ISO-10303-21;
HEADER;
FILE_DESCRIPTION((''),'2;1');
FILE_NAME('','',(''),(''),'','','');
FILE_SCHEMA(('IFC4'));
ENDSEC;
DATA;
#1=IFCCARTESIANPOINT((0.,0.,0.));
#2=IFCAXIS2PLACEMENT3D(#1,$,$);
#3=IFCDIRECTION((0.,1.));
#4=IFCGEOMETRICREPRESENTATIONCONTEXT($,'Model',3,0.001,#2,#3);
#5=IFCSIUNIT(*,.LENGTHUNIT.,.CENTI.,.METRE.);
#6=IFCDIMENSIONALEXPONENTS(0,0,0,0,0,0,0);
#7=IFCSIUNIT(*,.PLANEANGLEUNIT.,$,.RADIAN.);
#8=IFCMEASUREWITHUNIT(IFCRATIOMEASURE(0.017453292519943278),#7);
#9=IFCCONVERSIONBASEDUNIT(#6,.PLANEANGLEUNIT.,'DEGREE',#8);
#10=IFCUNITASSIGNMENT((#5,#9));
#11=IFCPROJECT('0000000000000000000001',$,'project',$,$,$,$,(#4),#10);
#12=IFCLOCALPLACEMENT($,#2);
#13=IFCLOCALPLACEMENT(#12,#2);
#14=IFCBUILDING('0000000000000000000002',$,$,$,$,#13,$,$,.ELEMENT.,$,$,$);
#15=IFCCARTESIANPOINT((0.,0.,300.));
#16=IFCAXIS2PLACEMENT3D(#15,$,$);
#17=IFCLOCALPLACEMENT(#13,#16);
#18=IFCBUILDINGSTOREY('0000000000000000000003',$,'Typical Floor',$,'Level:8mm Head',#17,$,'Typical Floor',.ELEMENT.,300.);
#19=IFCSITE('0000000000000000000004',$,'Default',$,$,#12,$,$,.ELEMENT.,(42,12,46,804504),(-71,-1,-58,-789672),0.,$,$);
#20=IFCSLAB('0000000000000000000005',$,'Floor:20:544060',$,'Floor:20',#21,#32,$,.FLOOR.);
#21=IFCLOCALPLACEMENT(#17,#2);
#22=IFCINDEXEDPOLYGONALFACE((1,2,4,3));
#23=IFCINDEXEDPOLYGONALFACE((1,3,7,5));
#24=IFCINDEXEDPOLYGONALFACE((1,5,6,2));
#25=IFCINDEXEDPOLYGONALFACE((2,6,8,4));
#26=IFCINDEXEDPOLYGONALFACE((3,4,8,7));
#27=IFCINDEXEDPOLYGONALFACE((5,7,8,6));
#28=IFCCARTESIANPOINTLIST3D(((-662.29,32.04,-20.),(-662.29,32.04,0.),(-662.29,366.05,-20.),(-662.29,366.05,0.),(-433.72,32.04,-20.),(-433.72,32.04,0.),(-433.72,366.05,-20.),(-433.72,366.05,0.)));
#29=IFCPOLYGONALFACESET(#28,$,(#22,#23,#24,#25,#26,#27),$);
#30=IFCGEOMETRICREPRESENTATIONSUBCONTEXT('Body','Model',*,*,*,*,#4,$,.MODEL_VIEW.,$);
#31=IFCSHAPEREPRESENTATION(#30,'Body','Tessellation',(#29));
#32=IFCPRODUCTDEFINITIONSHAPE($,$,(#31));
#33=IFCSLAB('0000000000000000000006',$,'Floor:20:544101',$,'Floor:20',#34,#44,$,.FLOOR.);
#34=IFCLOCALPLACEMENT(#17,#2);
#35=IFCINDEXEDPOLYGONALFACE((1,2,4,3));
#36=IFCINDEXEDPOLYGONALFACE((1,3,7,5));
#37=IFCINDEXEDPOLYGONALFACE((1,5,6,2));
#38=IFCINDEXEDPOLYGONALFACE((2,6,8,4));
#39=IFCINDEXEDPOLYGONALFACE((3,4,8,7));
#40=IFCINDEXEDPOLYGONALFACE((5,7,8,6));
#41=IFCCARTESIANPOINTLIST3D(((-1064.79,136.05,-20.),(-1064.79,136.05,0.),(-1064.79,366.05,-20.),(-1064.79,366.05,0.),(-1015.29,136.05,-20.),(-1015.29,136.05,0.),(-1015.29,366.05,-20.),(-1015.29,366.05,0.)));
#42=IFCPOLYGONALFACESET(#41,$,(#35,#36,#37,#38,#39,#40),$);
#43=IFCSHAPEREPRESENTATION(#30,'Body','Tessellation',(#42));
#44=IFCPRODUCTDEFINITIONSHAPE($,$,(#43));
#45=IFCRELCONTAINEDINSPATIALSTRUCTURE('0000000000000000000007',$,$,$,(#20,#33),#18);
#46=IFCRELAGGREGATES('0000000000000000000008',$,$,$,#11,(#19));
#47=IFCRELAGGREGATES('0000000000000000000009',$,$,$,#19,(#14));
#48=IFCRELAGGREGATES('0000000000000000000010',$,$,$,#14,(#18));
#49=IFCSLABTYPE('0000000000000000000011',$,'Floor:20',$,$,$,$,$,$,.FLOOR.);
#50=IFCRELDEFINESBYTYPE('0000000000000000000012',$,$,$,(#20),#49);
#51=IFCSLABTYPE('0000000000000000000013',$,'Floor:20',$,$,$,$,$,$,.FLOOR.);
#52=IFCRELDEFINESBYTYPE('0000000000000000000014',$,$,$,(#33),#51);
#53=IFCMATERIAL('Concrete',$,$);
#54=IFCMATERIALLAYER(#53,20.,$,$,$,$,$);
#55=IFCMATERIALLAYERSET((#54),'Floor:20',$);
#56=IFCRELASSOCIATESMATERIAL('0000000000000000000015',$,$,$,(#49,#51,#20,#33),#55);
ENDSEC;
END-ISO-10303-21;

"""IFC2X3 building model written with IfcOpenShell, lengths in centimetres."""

from ifc_helpers import new_model, entity, si_unit, converted_unit, direction, frame, frame_2d, origin, origin_2d_with_axis, place, context, subcontext, project, spatial, rectangle, extrude, material, layer, layer_set, layer_usage, type_object, element, save


model = new_model("IFC2X3")

# Units and contexts
model_context = context("Model", 3, precision=0.001, world=origin(), true_north=direction((0.0, 1.0)))
body_context = subcontext(model_context, "Body", "Model", "MODEL_VIEW")
ifc_project = project(units=[si_unit("LENGTHUNIT", "METRE", prefix="CENTI"), converted_unit("PLANEANGLEUNIT", "DEGREE", entity("IfcRatioMeasure", 0.017453292519943278), si_unit("PLANEANGLEUNIT", "RADIAN"), dimensions=[0, 0, 0, 0, 0, 0, 0])], contexts=[model_context])

# Site, building, storey
site_placement = place(None, origin())
site = spatial("IfcSite", under=ifc_project, at=site_placement, Name="Default", CompositionType="ELEMENT", RefLatitude=(42, 12, 46, 804504), RefLongitude=(-71, -1, -58, -789672), RefElevation=0.0)
building_placement = place(site_placement, origin())
building = spatial("IfcBuilding", under=site, at=building_placement, CompositionType="ELEMENT")
storey_placement = place(building_placement, frame((0.0, 0.0, 300.0)))
storey = spatial("IfcBuildingStorey", under=building, at=storey_placement, Name="Typical Floor", ObjectType="Level:8mm Head", LongName="Typical Floor", CompositionType="ELEMENT", Elevation=300.0)

# Shared definitions
ifc_material = material(Name="Concrete")

# Slabs
ifc_layer = layer(ifc_material, 20.0)
ifc_layer_set = layer_set([ifc_layer], Name="Floor:20")
ifc_layer_usage_1 = layer_usage(ifc_layer_set, "AXIS3", "POSITIVE", 0.0)
slab_type_1 = type_object("IfcSlabType", Name="Floor:20", PredefinedType="FLOOR", material=ifc_layer_set)
slab_1_placement = place(storey_placement, origin())
element("IfcSlab", 1, at=slab_1_placement, inside=storey, type_object=slab_type_1, material=ifc_layer_usage_1, Name="Floor:20:544060", ObjectType="Floor:20", PredefinedType="FLOOR", context=body_context, shape_type="SweptSolid", body=[
    extrude(rectangle(XDim=334.0, YDim=228.56, at=origin_2d_with_axis()), frame((-548.01, 199.05, 0.0), z_axis=(0.0, 0.0, -1.0), x_axis=(0.0, 1.0, 0.0)), (0.0, 0.0, 1.0), 20.0),
])
ifc_layer_usage_2 = layer_usage(ifc_layer_set, "AXIS3", "POSITIVE", 0.0)
slab_type_2 = type_object("IfcSlabType", Name="Floor:20", PredefinedType="FLOOR", material=ifc_layer_set)
slab_2_placement = place(storey_placement, origin())
element("IfcSlab", 2, at=slab_2_placement, inside=storey, type_object=slab_type_2, material=ifc_layer_usage_2, Name="Floor:20:544101", ObjectType="Floor:20", PredefinedType="FLOOR", context=body_context, shape_type="SweptSolid", body=[
    extrude(rectangle(XDim=230.0, YDim=49.5, at=frame_2d((0.0, 0.0), x_axis=(1.0, 0.0))), frame((-1040.04, 251.05, 0.0), z_axis=(0.0, 0.0, -1.0), x_axis=(0.0, 1.0, 0.0)), (0.0, 0.0, 1.0), 20.0),
])

save(model, "model.ifc")
